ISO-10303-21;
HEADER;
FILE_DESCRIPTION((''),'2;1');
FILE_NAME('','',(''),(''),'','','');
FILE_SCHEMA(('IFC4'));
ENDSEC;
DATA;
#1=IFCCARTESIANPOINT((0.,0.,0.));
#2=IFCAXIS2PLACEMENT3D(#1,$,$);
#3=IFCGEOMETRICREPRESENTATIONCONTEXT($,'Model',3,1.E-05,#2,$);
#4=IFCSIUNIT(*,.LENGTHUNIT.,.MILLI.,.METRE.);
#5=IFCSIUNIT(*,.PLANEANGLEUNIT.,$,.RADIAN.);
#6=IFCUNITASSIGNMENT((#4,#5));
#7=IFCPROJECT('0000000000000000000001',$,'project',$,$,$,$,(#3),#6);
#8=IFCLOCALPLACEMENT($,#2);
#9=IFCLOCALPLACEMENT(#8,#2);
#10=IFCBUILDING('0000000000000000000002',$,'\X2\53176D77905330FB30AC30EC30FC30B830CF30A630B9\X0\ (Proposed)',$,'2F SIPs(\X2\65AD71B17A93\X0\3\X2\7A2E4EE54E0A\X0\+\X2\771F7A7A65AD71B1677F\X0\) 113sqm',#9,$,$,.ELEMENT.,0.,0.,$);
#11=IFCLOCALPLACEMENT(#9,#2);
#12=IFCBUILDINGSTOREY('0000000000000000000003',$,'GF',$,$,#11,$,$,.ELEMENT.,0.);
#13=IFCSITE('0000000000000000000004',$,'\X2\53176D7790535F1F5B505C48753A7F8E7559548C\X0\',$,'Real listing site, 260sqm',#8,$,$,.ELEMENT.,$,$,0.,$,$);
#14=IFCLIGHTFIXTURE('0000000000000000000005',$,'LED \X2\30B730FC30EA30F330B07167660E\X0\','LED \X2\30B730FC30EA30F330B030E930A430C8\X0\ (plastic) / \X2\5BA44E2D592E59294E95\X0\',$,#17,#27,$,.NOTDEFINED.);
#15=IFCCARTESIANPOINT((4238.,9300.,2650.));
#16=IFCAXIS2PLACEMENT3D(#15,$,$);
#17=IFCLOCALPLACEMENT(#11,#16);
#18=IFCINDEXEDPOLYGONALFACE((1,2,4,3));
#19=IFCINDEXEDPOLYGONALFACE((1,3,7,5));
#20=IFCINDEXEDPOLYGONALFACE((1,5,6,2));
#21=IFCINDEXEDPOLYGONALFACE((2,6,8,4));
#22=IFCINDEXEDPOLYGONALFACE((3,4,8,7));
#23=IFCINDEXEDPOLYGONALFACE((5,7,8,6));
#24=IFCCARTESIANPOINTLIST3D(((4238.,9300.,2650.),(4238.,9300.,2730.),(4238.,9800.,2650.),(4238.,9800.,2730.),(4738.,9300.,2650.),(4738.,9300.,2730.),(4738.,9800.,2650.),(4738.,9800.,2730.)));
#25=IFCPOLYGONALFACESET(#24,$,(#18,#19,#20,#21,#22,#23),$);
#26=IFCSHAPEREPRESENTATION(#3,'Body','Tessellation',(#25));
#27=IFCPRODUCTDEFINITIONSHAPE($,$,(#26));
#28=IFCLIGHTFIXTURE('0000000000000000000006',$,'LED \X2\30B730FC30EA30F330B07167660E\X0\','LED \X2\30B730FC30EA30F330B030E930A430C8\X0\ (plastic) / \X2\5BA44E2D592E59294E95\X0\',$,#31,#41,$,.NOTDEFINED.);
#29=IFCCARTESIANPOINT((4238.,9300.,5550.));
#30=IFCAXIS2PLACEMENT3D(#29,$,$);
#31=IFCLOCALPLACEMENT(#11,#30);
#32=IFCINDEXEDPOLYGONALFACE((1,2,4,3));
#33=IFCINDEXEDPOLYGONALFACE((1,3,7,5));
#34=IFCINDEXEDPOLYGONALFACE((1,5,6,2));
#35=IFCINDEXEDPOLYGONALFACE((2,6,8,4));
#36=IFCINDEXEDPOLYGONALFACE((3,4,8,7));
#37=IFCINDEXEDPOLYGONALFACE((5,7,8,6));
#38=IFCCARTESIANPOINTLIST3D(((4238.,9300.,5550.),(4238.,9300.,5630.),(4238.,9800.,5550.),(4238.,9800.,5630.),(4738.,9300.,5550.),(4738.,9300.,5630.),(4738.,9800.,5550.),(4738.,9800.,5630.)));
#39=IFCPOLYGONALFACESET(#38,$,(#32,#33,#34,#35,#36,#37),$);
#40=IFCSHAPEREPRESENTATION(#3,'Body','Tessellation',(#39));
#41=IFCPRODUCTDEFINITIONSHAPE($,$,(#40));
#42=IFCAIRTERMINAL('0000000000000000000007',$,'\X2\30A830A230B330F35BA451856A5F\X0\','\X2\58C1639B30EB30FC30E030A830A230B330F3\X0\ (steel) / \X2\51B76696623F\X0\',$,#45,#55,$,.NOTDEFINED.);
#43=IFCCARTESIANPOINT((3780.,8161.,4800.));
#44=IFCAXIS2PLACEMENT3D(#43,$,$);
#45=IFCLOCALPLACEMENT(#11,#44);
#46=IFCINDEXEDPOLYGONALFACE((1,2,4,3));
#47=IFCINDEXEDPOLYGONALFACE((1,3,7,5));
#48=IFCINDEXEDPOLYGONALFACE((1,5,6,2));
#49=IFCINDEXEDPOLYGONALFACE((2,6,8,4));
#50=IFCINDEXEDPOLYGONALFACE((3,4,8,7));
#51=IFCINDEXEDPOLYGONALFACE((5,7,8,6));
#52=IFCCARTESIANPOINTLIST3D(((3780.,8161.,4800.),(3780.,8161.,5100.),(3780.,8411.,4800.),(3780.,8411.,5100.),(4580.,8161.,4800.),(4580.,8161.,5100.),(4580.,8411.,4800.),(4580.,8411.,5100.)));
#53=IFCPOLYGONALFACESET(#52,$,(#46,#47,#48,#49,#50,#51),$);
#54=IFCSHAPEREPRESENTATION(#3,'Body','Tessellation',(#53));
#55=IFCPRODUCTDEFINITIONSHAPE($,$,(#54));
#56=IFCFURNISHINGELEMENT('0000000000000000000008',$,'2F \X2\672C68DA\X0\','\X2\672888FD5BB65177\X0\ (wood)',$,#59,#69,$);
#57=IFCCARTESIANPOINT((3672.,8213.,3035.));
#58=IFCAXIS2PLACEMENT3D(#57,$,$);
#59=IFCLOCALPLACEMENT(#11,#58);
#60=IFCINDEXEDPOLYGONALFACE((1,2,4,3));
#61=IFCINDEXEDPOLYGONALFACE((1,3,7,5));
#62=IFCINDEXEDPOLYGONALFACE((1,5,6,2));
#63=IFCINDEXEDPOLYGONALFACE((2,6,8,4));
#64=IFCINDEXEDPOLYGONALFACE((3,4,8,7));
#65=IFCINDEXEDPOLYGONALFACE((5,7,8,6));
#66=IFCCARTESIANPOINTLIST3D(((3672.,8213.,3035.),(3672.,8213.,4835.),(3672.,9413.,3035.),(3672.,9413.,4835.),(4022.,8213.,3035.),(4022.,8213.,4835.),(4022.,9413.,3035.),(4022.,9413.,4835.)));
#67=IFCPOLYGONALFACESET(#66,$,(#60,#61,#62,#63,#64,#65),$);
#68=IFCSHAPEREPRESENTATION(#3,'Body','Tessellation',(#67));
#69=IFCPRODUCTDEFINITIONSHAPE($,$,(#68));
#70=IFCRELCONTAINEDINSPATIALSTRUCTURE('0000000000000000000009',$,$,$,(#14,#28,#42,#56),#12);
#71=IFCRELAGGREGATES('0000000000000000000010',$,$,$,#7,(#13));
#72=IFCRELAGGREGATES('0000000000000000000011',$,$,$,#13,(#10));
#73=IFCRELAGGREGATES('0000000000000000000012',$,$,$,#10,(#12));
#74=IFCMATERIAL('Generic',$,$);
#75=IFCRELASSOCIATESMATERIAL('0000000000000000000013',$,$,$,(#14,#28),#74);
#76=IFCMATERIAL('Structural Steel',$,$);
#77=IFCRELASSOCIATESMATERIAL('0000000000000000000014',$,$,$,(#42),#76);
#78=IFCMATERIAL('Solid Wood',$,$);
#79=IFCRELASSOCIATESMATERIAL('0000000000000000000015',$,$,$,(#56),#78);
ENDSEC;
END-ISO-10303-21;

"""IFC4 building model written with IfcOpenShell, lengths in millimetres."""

from ifc_helpers import new_model, si_unit, frame, frame_2d, origin, place, context, project, spatial, rectangle, extrude, material, element, save


model = new_model("IFC4")

# Units and contexts
model_context = context("Model", 3, precision=1e-05, world=origin())
ifc_project = project(units=[si_unit("LENGTHUNIT", "METRE", prefix="MILLI"), si_unit("PLANEANGLEUNIT", "RADIAN")], contexts=[model_context])

# Site, building, storey
site_placement = place(None, origin())
site = spatial("IfcSite", under=ifc_project, at=site_placement, Name="北海道弟子屈町美留和", ObjectType="Real listing site, 260sqm", CompositionType="ELEMENT", RefElevation=0.0)
building_placement = place(site_placement, origin())
building = spatial("IfcBuilding", under=site, at=building_placement, Name="北海道・ガレージハウス (Proposed)", ObjectType="2F SIPs(断熱窓3種以上+真空断熱板) 113sqm", CompositionType="ELEMENT", ElevationOfRefHeight=0.0, ElevationOfTerrain=0.0)
storey_placement = place(building_placement, origin())
storey = spatial("IfcBuildingStorey", under=building, at=storey_placement, Name="GF", CompositionType="ELEMENT", Elevation=0.0)

# Shared definitions
ifc_material_1 = material(Name="Solid Wood")

# Shared definitions
ifc_material_2 = material(Name="Structural Steel")

# Shared definitions
ifc_material_3 = material(Name="Generic")

# Light fixtures
light_fixture_1_placement = place(storey_placement, frame((4238.0, 9300.0, 2650.0)))
element("IfcLightFixture", 1, at=light_fixture_1_placement, inside=storey, material=ifc_material_3, Name="LED シーリング照明", Description="LED シーリングライト (plastic) / 室中央天井", PredefinedType="NOTDEFINED", context=model_context, shape_type="SweptSolid", body=[
    extrude(rectangle(XDim=500.0, YDim=500.0, at=frame_2d((250.0, 250.0))), frame((4238.0, 9300.0, 2650.0)), (0.0, 0.0, 1.0), 80.0),
])
light_fixture_2_placement = place(storey_placement, frame((4238.0, 9300.0, 5550.0)))
element("IfcLightFixture", 2, at=light_fixture_2_placement, inside=storey, material=ifc_material_3, Name="LED シーリング照明", Description="LED シーリングライト (plastic) / 室中央天井", PredefinedType="NOTDEFINED", context=model_context, shape_type="SweptSolid", body=[
    extrude(rectangle(XDim=500.0, YDim=500.0, at=frame_2d((250.0, 250.0))), frame((4238.0, 9300.0, 5550.0)), (0.0, 0.0, 1.0), 80.0),
])

# Air terminal
air_terminal_placement = place(storey_placement, frame((3780.0, 8161.0, 4800.0)))
element("IfcAirTerminal", 3, at=air_terminal_placement, inside=storey, material=ifc_material_2, Name="エアコン室内機", Description="壁掛ルームエアコン (steel) / 冷暖房", PredefinedType="NOTDEFINED", context=model_context, shape_type="SweptSolid", body=[
    extrude(rectangle(XDim=800.0, YDim=250.0, at=frame_2d((400.0, 125.0))), frame((3780.0, 8161.0, 4800.0)), (0.0, 0.0, 1.0), 300.0),
])

# Furnishing element
furnishing_placement = place(storey_placement, frame((3672.0, 8213.0, 3035.0)))
element("IfcFurnishingElement", 4, at=furnishing_placement, inside=storey, material=ifc_material_1, Name="2F 本棚", Description="木製家具 (wood)", context=model_context, shape_type="SweptSolid", body=[
    extrude(rectangle(XDim=350.0, YDim=1200.0, at=frame_2d((175.0, 600.0))), frame((3672.0, 8213.0, 3035.0)), (0.0, 0.0, 1.0), 1800.0),
])

save(model, "model.ifc")
